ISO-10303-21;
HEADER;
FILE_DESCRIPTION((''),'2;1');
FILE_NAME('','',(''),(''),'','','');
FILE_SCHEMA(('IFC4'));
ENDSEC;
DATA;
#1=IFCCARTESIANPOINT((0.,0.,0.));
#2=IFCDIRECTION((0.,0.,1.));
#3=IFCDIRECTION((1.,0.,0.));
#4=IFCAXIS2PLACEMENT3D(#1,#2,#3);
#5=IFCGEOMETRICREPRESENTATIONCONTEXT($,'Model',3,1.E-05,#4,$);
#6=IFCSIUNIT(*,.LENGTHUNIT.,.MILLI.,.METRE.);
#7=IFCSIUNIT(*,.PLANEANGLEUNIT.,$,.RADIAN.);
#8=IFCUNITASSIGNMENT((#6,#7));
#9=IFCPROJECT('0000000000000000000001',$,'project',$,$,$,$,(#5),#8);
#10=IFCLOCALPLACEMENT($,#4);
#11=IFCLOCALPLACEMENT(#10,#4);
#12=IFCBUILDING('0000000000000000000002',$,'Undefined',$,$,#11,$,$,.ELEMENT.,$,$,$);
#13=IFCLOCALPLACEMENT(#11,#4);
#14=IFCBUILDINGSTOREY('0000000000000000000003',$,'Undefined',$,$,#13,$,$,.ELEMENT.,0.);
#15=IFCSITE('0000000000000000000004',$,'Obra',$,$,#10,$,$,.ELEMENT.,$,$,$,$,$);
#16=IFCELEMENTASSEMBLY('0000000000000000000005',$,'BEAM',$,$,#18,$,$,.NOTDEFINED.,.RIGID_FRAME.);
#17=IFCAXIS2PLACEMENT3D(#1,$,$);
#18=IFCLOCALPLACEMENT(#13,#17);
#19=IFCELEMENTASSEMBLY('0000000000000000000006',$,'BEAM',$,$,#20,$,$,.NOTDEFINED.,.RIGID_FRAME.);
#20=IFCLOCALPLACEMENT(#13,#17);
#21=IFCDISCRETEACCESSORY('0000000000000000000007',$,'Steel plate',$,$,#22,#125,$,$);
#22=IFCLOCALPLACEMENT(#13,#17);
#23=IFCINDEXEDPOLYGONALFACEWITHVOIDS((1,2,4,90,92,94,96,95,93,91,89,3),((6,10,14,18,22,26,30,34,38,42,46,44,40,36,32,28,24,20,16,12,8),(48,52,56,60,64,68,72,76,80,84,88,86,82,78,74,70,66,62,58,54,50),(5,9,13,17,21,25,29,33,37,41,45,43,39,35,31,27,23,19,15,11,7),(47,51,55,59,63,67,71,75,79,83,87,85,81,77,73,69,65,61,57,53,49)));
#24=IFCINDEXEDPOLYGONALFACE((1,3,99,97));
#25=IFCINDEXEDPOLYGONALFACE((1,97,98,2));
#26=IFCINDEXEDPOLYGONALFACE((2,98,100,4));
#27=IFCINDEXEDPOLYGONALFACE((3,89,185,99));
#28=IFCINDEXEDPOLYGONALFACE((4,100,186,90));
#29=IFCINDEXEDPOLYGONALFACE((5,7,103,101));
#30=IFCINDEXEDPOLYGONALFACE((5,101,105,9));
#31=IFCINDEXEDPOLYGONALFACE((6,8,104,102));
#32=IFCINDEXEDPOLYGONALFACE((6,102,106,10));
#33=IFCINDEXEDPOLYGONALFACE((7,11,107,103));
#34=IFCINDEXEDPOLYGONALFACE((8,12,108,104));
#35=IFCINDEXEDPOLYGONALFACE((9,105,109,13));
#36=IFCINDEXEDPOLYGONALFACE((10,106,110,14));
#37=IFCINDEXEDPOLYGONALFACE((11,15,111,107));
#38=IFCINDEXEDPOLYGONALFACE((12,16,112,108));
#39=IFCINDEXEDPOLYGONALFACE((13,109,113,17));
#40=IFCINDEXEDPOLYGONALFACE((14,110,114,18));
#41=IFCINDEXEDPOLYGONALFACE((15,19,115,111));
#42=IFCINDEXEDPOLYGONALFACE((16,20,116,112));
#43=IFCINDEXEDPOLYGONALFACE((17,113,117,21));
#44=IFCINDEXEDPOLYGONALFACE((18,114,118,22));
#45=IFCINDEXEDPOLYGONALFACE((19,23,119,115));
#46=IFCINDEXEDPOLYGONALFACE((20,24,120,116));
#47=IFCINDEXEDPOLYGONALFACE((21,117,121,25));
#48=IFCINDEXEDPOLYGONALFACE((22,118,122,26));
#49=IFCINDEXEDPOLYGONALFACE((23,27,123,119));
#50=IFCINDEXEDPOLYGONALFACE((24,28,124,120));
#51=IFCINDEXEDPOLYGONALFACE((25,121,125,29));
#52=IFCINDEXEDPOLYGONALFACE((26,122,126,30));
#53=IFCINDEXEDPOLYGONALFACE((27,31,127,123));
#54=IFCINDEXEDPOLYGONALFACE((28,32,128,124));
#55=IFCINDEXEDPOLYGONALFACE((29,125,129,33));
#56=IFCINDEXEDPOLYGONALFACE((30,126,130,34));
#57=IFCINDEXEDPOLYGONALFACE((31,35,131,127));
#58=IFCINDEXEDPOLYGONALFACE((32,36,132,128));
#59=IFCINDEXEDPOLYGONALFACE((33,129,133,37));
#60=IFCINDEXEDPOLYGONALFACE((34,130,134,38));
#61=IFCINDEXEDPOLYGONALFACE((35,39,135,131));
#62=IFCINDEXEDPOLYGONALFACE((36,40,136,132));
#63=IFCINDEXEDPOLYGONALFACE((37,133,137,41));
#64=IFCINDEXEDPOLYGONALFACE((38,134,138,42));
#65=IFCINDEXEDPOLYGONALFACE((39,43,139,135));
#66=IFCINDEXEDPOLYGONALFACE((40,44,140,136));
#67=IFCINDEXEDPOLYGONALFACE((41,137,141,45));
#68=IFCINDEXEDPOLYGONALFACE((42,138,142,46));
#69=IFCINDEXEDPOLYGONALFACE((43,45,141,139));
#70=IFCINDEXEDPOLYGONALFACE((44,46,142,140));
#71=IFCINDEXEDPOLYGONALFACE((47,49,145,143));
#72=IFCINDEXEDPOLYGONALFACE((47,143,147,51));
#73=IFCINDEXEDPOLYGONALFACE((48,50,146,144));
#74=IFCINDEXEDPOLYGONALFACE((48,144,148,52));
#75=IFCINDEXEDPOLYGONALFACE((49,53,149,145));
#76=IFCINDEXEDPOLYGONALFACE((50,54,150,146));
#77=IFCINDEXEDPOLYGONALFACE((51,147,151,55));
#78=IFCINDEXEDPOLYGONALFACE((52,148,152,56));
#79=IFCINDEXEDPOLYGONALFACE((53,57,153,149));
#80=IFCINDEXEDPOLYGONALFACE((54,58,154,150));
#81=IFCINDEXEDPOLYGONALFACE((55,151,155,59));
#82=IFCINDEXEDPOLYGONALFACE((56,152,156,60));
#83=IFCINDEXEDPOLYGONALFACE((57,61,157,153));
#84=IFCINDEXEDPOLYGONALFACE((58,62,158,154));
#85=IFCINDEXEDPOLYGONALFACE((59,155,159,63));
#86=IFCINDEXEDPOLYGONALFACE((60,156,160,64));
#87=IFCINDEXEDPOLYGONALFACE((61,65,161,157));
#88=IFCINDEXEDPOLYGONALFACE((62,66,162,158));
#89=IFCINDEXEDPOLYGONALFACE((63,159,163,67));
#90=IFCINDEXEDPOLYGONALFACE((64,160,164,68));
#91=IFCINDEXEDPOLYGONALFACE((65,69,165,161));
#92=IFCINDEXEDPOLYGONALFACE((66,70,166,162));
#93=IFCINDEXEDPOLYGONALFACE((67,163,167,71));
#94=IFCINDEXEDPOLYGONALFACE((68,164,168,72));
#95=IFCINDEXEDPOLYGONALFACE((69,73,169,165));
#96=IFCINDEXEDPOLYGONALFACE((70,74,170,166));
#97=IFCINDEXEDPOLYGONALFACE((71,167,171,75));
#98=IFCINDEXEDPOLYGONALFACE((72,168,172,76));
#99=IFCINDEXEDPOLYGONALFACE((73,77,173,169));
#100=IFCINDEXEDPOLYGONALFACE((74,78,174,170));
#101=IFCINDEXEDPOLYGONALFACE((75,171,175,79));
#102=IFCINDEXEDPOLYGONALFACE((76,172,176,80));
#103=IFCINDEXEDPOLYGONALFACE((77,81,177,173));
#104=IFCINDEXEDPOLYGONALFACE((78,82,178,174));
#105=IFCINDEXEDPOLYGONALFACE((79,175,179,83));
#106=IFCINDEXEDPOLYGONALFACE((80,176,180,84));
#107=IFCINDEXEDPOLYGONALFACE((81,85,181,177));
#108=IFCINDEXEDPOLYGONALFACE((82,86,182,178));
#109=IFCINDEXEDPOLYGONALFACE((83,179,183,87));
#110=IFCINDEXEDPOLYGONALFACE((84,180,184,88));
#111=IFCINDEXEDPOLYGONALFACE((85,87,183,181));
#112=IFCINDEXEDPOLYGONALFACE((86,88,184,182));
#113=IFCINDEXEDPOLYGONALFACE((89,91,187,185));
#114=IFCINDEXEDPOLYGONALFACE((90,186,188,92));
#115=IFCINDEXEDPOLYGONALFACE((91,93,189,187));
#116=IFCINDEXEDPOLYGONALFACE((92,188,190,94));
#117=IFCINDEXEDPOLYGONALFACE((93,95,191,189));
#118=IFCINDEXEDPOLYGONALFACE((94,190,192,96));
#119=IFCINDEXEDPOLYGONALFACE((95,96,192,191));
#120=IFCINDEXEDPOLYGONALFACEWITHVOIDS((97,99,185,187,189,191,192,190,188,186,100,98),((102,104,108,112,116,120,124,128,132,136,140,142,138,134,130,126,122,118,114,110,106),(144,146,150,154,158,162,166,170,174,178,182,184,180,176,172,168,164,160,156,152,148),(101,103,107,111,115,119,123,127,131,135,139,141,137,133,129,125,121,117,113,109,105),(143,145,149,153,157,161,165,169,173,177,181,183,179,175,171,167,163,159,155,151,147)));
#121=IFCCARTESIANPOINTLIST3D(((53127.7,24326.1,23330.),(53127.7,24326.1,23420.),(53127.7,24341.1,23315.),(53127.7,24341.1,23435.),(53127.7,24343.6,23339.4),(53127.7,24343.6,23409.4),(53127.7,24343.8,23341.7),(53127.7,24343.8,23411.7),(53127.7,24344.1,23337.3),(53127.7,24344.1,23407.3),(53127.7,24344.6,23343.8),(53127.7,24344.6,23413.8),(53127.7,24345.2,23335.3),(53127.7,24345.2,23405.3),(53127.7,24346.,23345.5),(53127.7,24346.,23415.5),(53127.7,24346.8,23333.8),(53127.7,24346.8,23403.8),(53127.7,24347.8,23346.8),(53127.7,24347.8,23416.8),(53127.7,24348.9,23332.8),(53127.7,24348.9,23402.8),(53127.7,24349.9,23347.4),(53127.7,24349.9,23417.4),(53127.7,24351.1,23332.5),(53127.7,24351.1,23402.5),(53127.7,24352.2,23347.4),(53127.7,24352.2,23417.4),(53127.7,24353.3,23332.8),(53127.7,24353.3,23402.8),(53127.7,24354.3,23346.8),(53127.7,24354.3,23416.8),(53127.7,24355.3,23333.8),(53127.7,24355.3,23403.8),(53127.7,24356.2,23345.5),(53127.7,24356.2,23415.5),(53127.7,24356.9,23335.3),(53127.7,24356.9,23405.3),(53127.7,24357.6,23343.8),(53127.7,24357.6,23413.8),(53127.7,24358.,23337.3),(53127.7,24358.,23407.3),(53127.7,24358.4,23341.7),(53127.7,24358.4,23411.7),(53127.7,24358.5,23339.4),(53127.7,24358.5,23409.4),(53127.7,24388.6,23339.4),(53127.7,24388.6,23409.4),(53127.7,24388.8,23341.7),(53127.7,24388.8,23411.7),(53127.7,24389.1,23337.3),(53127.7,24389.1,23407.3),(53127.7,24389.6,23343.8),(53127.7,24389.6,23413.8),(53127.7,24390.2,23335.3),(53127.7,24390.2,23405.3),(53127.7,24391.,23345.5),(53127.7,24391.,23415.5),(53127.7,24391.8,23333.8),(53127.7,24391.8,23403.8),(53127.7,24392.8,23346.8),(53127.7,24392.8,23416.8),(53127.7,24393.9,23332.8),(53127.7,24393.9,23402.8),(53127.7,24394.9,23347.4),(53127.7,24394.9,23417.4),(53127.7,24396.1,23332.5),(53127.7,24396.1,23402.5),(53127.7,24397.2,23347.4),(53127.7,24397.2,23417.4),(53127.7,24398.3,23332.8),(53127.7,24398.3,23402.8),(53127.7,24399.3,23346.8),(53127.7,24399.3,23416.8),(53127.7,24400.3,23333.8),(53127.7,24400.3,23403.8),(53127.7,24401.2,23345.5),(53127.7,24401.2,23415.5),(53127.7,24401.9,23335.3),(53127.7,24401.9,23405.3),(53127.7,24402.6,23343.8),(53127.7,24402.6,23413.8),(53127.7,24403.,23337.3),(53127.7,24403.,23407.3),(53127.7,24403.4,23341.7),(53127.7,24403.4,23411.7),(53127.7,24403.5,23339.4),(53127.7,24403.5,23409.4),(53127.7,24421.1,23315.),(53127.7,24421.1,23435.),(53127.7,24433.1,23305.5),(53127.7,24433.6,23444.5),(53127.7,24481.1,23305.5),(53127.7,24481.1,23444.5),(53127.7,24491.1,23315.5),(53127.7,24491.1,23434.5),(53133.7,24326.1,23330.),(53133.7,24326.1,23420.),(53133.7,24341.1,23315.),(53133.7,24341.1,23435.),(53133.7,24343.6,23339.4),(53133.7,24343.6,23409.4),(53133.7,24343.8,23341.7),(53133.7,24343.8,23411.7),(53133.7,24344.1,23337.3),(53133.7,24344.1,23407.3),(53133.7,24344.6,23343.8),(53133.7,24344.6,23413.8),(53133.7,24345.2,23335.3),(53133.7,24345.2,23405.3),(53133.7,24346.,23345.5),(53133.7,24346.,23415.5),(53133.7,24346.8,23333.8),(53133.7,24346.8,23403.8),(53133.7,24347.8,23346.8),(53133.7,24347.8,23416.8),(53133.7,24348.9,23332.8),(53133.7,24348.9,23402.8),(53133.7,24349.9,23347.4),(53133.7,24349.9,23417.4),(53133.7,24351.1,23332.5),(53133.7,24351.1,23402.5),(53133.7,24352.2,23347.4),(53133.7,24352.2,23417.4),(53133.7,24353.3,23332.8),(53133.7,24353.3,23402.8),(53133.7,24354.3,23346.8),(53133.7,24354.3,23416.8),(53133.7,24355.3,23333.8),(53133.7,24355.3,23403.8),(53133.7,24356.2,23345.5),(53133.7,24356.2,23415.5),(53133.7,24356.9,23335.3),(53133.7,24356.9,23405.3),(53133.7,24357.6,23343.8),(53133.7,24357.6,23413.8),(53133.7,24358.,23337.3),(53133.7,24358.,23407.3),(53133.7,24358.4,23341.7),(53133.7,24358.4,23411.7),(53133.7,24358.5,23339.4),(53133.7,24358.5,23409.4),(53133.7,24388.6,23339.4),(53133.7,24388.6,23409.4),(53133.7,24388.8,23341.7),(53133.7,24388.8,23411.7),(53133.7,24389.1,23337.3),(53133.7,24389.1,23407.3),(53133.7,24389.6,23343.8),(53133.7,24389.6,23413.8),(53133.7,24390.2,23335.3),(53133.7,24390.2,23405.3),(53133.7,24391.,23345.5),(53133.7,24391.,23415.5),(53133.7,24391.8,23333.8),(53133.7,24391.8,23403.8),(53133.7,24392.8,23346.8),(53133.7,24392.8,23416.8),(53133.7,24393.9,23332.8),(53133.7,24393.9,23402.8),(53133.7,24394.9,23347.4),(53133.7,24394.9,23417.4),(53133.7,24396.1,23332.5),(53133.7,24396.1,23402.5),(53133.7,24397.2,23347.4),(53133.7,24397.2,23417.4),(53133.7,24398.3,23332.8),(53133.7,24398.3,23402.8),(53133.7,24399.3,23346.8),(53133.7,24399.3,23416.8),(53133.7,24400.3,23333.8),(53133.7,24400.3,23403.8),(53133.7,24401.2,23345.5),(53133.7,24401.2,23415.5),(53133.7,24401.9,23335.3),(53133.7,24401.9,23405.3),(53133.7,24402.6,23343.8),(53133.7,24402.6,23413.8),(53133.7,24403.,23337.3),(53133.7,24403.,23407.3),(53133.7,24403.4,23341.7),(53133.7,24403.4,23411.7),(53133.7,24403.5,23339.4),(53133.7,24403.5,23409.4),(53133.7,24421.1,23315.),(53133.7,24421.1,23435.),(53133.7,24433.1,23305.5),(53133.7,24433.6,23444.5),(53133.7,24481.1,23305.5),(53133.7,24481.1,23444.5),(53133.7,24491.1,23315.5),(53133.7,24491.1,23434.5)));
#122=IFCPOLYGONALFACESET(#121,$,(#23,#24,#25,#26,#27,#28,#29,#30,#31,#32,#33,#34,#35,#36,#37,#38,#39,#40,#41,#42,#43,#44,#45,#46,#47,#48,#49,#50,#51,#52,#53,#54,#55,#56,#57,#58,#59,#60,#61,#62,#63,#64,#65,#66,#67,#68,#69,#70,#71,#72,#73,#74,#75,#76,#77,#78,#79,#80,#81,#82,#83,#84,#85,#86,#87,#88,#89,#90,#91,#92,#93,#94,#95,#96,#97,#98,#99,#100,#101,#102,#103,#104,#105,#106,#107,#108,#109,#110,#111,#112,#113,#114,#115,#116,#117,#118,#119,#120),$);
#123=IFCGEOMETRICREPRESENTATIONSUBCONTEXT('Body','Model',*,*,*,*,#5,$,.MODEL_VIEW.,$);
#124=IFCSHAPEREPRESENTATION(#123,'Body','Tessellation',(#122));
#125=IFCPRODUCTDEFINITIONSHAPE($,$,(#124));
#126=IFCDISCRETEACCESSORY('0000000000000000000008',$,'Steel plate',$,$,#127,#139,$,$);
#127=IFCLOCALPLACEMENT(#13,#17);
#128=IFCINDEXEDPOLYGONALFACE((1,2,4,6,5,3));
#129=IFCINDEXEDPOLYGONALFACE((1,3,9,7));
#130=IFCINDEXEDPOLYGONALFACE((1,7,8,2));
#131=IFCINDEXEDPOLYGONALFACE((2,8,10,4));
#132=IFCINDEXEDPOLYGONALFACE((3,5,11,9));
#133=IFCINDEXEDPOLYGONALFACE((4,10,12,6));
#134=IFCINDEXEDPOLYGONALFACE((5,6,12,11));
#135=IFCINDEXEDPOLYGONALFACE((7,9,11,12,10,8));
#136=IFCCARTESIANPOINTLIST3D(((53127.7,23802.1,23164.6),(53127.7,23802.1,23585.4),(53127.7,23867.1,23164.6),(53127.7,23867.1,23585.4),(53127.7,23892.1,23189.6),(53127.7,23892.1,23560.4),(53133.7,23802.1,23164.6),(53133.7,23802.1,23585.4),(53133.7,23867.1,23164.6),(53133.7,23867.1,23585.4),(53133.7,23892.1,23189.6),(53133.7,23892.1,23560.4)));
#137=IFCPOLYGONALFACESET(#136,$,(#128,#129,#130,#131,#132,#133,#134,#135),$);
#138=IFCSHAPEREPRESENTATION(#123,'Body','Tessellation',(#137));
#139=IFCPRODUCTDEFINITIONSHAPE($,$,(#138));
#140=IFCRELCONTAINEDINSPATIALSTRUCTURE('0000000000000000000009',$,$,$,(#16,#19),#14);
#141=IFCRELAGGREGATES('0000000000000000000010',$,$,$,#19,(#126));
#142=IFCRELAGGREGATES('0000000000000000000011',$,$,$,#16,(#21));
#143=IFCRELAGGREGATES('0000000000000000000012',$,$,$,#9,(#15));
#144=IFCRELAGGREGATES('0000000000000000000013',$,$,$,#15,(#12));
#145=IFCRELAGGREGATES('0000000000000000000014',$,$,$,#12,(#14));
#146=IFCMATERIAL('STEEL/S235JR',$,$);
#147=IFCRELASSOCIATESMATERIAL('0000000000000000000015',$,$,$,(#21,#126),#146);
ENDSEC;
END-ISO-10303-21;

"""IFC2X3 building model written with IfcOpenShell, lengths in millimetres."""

from ifc_helpers import new_model, si_unit, frame, origin_with_axes, origin_2d_with_axis, place, context, subcontext, project, spatial, polyline, circle, outline, extrude, source, transform, mapped, material, element, aggregate, save


model = new_model("IFC2X3")

# Units and contexts
model_context = context("Model", 3, precision=1e-05, world=origin_with_axes())
body_context = subcontext(model_context, "Body", "Model", "MODEL_VIEW")
ifc_project = project(units=[si_unit("LENGTHUNIT", "METRE", prefix="MILLI"), si_unit("PLANEANGLEUNIT", "RADIAN")], contexts=[model_context])

# Site, building, storey
site_placement = place(None, origin_with_axes())
site = spatial("IfcSite", under=ifc_project, at=site_placement, Name="Obra", CompositionType="ELEMENT")
building_placement = place(site_placement, origin_with_axes())
building = spatial("IfcBuilding", under=site, at=building_placement, Name="Undefined", CompositionType="ELEMENT")
storey_placement = place(building_placement, origin_with_axes())
storey = spatial("IfcBuildingStorey", under=building, at=storey_placement, Name="Undefined", CompositionType="ELEMENT", Elevation=0.0)

# Shared definitions
ifc_material_1 = material(Name="STEEL/S235JR")

# Element assembly
assembly_1_placement = place(storey_placement, origin_with_axes())
assembly_1 = element("IfcElementAssembly", 1, at=assembly_1_placement, inside=storey, Name="BEAM", AssemblyPlace="NOTDEFINED", PredefinedType="RIGID_FRAME")
shared_shape_1 = source(origin_with_axes(), body_context, "Body", "SweptSolid", [
    extrude(circle(Radius=7.5, at=origin_2d_with_axis()), frame((0.0, 2.4, 0.0), z_axis=(0.0, 1.0, 0.0), x_axis=(1.0, 0.0, 0.0)), (0.0, 0.0, 1.0), 6.2),
])

# Element assembly
assembly_2_placement = place(storey_placement, origin_with_axes())
assembly_2 = element("IfcElementAssembly", 2, at=assembly_2_placement, inside=storey, Name="BEAM", AssemblyPlace="NOTDEFINED", PredefinedType="RIGID_FRAME")

# Discrete accessory, opening
discrete_accessory_1_placement = place(assembly_1_placement, frame((53130.7, 24491.1, 23315.5), z_axis=(-1.0, 0.0, 0.0), x_axis=(0.0, -0.707107, -0.707107)))
discrete_accessory_1 = element("IfcDiscreteAccessory", 3, at=discrete_accessory_1_placement, material=ifc_material_1, Name="Steel plate", context=body_context, shape_type="SweptSolid", body=[
    extrude(outline(polyline([(0.0, 0.0), (14.1, 0.0), (48.1, 33.9), (49.9, 49.1), (106.4, 105.7), (106.4, 126.9), (42.8, 190.6), (21.6, 190.6), (-35.0, 134.0), (-50.6, 131.9), (-84.1, 98.3), (-84.1, 84.1), (0.0, 0.0)])), frame((0.0, 0.0, -3.0), z_axis=(0.0, 0.0, 1.0), x_axis=(1.0, 0.0, 0.0)), (0.0, 0.0, 1.0), 6.0),
])
opening_1_placement = place(assembly_1_placement, frame((53125.2, 24373.6, 23410.0), z_axis=(0.0, -1.0, 0.0), x_axis=(0.0, 0.0, -1.0)))
element("IfcOpeningElement", 4, at=opening_1_placement, cuts=discrete_accessory_1, ObjectType="Opening", context=body_context, shape_type="MappedRepresentation", body=[
    mapped(shared_shape_1, transform((0.0, 0.0, -22.5))),
    mapped(shared_shape_1, transform((70.0, 0.0, -22.5))),
    mapped(shared_shape_1, transform((0.0, 0.0, 22.5))),
    mapped(shared_shape_1, transform((70.0, 0.0, 22.5))),
])

# Discrete accessory
discrete_accessory_2_placement = place(assembly_2_placement, frame((53130.7, 23892.1, 23164.6), z_axis=(-1.0, 0.0, 0.0), x_axis=(0.0, -1.0, 0.0)))
discrete_accessory_2 = element("IfcDiscreteAccessory", 5, at=discrete_accessory_2_placement, material=ifc_material_1, Name="Steel plate", context=body_context, shape_type="SweptSolid", body=[
    extrude(outline(polyline([(0.0, 25.0), (25.0, 0.0), (90.0, 0.0), (90.0, 420.8), (25.0, 420.8), (0.0, 395.8), (0.0, 25.0)])), frame((0.0, 0.0, -3.0), z_axis=(0.0, 0.0, 1.0), x_axis=(1.0, 0.0, 0.0)), (0.0, 0.0, 1.0), 6.0),
])

aggregate(assembly_2, [discrete_accessory_2])
aggregate(assembly_1, [discrete_accessory_1])

save(model, "model.ifc")
